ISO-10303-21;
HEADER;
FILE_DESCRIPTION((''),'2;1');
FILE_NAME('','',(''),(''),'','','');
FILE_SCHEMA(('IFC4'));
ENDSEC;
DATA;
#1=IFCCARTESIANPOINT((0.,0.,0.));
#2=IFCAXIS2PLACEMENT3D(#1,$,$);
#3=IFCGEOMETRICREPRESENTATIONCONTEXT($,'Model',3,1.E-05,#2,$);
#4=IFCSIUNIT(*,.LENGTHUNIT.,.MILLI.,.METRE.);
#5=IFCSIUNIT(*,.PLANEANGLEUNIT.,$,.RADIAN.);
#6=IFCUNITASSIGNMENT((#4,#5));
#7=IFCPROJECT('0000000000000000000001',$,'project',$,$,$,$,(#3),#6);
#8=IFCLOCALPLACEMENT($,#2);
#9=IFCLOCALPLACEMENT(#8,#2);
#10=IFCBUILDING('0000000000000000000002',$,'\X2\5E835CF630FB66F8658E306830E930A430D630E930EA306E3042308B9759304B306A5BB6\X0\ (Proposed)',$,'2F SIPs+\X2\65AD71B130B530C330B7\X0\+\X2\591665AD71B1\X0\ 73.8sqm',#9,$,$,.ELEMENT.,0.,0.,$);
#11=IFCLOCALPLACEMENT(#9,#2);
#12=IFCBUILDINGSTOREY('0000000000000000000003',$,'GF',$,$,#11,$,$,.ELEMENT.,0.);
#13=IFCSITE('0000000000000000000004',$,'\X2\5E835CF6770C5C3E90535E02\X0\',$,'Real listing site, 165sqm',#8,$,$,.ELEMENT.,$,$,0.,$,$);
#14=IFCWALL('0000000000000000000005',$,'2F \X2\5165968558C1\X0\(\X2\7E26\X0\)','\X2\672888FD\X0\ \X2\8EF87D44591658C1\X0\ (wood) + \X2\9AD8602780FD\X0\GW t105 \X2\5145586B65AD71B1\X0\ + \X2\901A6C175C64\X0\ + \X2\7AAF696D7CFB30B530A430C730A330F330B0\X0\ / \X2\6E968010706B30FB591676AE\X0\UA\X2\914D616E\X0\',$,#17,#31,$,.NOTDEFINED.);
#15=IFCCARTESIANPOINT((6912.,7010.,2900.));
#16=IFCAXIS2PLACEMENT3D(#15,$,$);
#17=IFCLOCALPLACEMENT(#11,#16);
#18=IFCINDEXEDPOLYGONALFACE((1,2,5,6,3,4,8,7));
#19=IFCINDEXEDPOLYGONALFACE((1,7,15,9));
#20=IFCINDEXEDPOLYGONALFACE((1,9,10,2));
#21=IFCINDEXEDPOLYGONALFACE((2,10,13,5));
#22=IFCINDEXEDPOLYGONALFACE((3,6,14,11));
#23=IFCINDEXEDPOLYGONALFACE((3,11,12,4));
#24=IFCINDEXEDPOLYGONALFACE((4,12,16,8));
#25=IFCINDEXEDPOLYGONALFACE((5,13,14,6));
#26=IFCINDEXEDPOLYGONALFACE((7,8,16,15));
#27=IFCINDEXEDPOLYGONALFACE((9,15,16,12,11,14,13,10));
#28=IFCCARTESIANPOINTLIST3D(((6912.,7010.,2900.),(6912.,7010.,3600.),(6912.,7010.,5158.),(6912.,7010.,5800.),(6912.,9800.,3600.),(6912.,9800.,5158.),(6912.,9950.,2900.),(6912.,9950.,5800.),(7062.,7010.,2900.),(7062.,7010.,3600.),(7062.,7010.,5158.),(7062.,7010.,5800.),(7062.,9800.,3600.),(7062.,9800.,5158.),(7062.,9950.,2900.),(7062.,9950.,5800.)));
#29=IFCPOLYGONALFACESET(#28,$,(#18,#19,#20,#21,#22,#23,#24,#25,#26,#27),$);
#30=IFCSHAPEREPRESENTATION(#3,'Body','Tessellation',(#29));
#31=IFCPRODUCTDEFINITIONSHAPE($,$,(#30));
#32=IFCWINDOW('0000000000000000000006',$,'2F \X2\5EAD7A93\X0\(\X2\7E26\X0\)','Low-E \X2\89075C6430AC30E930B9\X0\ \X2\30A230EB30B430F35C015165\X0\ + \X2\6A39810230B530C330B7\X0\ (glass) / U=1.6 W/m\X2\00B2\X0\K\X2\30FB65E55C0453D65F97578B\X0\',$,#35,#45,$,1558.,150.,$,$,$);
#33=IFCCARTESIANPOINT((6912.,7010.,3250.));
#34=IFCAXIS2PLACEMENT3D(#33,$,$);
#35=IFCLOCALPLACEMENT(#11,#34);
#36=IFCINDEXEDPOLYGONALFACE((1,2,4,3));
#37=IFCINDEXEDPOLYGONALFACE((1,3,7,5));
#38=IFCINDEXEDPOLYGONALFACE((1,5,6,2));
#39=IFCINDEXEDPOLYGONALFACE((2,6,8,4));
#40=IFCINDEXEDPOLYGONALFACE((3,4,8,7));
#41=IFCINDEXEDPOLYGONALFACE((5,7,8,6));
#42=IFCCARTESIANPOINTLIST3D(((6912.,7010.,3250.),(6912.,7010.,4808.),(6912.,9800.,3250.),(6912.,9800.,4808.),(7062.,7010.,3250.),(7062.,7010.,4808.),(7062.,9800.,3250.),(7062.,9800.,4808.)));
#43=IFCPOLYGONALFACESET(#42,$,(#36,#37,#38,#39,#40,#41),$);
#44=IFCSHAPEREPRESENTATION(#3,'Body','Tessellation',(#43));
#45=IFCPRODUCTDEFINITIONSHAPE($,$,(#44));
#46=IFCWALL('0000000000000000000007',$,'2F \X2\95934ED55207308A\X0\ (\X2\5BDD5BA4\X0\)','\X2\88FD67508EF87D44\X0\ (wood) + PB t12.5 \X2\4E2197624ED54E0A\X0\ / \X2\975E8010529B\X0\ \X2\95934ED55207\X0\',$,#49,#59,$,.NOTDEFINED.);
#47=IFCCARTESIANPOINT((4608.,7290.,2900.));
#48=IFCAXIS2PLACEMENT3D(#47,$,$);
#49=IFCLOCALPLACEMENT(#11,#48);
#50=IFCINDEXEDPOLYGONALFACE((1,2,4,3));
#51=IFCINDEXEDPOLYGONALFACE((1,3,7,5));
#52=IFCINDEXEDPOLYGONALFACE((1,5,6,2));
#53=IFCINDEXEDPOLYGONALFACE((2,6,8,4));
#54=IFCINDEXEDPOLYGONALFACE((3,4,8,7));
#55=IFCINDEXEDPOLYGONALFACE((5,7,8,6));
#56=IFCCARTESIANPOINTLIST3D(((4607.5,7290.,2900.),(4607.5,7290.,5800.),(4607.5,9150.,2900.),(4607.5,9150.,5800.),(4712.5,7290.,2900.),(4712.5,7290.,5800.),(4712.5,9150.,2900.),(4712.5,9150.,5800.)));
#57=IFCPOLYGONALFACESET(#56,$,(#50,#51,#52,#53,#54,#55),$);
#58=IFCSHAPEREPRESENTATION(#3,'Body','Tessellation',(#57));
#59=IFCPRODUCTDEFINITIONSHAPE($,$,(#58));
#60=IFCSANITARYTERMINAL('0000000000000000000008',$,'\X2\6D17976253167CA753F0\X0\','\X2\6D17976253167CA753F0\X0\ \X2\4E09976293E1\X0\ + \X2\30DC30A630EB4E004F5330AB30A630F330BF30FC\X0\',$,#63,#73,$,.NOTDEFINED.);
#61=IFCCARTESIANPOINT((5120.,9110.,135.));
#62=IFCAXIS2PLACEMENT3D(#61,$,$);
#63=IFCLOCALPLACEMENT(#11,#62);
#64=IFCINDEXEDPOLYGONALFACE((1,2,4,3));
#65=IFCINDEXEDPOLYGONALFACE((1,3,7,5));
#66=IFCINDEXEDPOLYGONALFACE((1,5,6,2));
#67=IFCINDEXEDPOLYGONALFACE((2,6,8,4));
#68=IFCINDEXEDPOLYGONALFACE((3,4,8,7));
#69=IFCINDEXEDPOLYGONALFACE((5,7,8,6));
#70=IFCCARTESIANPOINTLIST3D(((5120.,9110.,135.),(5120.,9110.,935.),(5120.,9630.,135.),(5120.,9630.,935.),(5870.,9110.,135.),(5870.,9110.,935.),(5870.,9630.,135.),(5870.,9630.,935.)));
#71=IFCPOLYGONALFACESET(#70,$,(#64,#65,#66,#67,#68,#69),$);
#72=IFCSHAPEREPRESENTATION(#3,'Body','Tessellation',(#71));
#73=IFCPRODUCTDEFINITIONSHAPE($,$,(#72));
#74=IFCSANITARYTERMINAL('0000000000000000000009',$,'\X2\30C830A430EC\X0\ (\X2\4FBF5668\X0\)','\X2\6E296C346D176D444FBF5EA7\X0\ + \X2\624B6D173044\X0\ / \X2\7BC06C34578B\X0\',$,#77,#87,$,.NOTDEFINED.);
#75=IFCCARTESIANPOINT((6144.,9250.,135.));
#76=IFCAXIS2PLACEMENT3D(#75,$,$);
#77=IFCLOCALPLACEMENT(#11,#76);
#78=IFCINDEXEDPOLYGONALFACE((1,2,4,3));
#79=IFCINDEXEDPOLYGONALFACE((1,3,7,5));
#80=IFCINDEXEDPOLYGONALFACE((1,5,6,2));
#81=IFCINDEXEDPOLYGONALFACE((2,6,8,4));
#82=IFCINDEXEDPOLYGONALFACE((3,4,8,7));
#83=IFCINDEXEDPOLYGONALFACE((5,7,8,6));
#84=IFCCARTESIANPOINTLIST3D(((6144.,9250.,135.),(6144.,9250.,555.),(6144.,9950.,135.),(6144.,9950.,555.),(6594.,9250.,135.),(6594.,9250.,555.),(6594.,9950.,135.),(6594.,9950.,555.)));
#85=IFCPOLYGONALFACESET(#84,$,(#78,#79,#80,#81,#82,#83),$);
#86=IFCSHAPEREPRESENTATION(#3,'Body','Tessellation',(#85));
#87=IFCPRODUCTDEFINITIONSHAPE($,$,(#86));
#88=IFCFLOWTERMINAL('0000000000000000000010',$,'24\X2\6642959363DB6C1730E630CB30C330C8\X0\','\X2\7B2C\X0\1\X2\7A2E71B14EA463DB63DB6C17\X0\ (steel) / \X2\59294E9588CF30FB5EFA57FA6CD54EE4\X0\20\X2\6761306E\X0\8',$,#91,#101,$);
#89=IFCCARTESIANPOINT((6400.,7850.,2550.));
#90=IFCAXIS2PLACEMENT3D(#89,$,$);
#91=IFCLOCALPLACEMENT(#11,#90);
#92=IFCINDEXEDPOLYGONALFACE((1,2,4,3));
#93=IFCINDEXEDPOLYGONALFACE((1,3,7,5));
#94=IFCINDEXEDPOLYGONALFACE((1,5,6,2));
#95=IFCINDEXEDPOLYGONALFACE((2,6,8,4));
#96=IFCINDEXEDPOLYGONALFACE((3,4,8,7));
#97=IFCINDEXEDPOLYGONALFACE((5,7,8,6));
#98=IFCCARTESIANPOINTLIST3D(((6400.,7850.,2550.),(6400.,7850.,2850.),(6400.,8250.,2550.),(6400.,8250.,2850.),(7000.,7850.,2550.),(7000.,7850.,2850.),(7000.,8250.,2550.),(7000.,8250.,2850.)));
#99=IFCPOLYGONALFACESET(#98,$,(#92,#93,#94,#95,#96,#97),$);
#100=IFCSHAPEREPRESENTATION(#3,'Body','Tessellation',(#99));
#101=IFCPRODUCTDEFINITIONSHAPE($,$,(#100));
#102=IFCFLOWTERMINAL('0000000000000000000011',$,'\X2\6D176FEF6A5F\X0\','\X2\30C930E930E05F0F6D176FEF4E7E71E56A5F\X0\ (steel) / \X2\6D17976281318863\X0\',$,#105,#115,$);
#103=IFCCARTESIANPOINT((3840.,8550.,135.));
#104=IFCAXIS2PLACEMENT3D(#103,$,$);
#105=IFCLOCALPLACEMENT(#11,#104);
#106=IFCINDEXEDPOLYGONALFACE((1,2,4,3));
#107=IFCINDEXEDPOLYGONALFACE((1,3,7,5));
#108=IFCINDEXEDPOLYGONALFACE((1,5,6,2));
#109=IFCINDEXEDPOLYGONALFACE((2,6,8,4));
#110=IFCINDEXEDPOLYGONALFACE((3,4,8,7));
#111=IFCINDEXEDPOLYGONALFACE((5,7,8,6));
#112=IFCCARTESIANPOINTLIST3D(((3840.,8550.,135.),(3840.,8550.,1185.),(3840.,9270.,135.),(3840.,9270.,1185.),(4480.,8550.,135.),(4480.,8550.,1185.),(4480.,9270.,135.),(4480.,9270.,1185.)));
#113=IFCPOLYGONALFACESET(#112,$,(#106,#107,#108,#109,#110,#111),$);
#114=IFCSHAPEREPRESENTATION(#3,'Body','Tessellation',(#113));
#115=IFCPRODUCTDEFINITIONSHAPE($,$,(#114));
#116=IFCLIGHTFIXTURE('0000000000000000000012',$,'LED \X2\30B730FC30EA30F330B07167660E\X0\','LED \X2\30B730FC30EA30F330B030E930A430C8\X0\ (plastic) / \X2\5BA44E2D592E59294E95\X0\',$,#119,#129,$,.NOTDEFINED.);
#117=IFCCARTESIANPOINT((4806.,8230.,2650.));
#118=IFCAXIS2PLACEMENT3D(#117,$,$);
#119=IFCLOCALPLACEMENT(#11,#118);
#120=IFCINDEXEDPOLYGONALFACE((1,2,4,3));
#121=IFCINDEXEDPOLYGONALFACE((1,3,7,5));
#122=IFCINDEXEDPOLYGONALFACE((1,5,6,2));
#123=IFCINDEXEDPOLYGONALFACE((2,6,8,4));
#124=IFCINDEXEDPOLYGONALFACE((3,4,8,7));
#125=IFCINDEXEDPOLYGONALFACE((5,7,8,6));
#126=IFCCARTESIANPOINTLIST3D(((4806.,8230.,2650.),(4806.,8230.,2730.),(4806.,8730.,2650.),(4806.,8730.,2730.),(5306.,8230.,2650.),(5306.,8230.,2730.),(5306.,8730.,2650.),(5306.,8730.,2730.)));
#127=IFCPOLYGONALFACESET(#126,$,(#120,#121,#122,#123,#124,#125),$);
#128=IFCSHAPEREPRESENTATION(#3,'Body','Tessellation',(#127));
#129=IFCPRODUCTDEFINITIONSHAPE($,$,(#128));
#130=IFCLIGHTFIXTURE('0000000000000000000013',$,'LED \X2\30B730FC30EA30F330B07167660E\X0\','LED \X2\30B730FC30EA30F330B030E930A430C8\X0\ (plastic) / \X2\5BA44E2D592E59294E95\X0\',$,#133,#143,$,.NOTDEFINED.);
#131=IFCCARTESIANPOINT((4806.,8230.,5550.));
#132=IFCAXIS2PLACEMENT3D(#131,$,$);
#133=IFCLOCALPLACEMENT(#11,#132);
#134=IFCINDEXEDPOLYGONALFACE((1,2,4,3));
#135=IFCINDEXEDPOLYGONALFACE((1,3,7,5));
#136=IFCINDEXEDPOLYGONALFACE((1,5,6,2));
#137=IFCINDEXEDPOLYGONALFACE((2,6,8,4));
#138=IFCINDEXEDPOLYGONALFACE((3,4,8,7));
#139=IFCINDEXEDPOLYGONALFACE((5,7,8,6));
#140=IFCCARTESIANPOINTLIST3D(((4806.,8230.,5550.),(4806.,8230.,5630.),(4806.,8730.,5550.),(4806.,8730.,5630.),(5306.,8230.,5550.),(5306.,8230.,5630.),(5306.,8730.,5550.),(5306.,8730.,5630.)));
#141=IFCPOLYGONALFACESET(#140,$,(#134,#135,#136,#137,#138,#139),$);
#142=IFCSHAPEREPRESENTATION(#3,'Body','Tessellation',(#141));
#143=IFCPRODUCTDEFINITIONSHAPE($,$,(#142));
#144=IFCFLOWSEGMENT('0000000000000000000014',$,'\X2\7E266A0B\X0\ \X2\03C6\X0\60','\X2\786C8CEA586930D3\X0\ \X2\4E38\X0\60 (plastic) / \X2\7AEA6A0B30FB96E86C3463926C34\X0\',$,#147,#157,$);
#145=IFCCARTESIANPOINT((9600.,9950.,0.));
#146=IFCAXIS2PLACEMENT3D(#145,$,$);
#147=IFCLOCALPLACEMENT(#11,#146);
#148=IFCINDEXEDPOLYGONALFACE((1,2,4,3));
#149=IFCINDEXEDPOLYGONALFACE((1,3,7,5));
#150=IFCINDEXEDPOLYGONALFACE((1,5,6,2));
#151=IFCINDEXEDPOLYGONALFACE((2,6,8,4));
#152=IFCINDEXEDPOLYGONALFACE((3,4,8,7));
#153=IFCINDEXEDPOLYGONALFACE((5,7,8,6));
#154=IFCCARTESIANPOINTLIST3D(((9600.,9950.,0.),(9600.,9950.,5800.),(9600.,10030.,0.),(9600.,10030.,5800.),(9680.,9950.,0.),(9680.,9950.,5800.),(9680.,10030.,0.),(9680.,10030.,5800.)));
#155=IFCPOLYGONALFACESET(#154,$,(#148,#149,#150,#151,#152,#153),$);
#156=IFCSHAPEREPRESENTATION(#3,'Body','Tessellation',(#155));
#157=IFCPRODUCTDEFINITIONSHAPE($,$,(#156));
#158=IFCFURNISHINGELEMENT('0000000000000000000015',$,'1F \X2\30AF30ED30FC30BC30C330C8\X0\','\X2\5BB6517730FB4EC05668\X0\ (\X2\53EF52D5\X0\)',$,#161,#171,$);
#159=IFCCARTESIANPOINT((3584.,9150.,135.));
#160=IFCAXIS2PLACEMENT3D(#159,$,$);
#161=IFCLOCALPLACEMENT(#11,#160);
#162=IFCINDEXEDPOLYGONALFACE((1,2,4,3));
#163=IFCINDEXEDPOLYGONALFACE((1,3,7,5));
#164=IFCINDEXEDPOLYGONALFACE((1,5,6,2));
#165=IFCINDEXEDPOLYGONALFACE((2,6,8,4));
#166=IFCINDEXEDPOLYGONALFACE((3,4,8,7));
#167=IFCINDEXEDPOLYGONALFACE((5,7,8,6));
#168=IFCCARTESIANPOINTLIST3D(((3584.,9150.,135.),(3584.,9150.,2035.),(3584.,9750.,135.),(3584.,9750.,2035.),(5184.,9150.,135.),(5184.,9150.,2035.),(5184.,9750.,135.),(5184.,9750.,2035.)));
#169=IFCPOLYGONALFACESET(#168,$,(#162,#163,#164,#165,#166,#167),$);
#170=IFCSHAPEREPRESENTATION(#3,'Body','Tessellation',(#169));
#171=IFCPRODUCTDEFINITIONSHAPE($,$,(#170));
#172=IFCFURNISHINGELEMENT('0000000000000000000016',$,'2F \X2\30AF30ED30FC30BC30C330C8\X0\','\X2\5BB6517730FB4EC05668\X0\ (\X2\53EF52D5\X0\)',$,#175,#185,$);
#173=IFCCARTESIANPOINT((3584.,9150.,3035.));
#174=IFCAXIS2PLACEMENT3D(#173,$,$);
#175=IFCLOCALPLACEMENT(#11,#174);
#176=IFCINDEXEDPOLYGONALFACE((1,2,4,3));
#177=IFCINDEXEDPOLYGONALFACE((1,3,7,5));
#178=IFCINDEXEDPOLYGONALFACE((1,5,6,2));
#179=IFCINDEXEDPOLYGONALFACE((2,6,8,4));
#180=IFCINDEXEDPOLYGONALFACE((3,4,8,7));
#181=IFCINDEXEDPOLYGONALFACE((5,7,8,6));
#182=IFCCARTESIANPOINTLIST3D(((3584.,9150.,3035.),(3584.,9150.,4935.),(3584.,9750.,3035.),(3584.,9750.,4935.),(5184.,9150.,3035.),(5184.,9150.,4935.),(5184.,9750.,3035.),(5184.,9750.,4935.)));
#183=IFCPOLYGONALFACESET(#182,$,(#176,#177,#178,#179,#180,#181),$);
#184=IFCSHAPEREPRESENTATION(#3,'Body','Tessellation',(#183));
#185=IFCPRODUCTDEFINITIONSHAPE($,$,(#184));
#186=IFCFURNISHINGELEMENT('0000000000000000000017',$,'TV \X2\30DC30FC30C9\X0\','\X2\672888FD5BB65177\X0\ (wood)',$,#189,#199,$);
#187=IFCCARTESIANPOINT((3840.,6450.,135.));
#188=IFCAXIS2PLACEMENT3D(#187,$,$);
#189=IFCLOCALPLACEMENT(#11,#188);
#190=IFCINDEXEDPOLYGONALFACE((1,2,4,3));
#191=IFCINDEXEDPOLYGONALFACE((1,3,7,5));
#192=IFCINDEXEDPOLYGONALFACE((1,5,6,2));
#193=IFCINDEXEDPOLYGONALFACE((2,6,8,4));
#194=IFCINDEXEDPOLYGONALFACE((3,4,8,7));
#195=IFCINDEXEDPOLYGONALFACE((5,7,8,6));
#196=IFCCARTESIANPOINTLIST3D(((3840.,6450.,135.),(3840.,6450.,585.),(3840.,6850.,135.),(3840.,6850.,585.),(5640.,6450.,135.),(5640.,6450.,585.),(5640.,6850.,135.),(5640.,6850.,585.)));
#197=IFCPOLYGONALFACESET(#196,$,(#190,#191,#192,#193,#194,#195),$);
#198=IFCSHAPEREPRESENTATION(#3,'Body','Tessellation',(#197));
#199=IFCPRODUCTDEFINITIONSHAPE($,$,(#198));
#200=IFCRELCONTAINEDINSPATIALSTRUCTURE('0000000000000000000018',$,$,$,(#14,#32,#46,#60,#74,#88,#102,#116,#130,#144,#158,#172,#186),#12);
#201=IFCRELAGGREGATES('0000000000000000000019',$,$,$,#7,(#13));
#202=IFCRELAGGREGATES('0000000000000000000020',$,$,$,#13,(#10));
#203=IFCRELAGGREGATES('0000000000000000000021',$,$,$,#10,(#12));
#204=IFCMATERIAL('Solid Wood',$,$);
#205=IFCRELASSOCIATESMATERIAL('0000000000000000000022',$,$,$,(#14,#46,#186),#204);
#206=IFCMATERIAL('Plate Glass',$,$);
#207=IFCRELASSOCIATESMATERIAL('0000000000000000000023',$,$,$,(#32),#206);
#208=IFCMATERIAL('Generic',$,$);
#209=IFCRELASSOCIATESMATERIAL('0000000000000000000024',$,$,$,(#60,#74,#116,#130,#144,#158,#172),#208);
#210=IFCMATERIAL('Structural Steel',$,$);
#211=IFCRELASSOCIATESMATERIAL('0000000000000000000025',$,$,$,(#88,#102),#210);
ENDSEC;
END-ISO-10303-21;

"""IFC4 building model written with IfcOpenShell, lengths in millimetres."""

from ifc_helpers import new_model, si_unit, frame, frame_2d, origin, place, context, project, spatial, rectangle, extrude, material, element, fill, save


model = new_model("IFC4")

# Units and contexts
model_context = context("Model", 3, precision=1e-05, world=origin())
ifc_project = project(units=[si_unit("LENGTHUNIT", "METRE", prefix="MILLI"), si_unit("PLANEANGLEUNIT", "RADIAN")], contexts=[model_context])

# Site, building, storey
site_placement = place(None, origin())
site = spatial("IfcSite", under=ifc_project, at=site_placement, Name="広島県尾道市", ObjectType="Real listing site, 165sqm", CompositionType="ELEMENT", RefElevation=0.0)
building_placement = place(site_placement, origin())
building = spatial("IfcBuilding", under=site, at=building_placement, Name="広島・書斎とライブラリのある静かな家 (Proposed)", ObjectType="2F SIPs+断熱サッシ+外断熱 73.8sqm", CompositionType="ELEMENT", ElevationOfRefHeight=0.0, ElevationOfTerrain=0.0)
storey_placement = place(building_placement, origin())
storey = spatial("IfcBuildingStorey", under=building, at=storey_placement, Name="GF", CompositionType="ELEMENT", Elevation=0.0)

# Shared definitions
ifc_material_1 = material(Name="Solid Wood")

# Shared definitions
ifc_material_2 = material(Name="Plate Glass")

# Wall, opening, window
wall_1_placement = place(storey_placement, frame((6912.0, 7010.0, 2900.0)))
wall_1 = element("IfcWall", 1, at=wall_1_placement, inside=storey, material=ifc_material_1, Name="2F 入隅壁(縦)", Description="木製 軸組外壁 (wood) + 高性能GW t105 充填断熱 + 通気層 + 窯業系サイディング / 準耐火・外皮UA配慮", PredefinedType="NOTDEFINED", context=model_context, shape_type="SweptSolid", body=[
    extrude(rectangle(XDim=150.0, YDim=2940.0, at=frame_2d((75.0, 1470.0))), frame((6912.0, 7010.0, 2900.0)), (0.0, 0.0, 1.0), 2900.0),
])
opening_1_placement = place(storey_placement, frame((6912.0, 7010.0, 3250.0)))
opening_1 = element("IfcOpeningElement", 2, at=opening_1_placement, cuts=wall_1, PredefinedType="NOTDEFINED", context=model_context, shape_type="SweptSolid", body=[
    extrude(rectangle(XDim=150.0, YDim=2790.0, at=frame_2d((75.0, 1395.0))), frame((6912.0, 7010.0, 3250.0)), (0.0, 0.0, 1.0), 1558.0),
])
window_1_placement = place(storey_placement, frame((6912.0, 7010.0, 3250.0)))
window_1 = element("IfcWindow", 3, at=window_1_placement, inside=storey, material=ifc_material_2, Name="2F 庭窓(縦)", Description="Low-E 複層ガラス アルゴン封入 + 樹脂サッシ (glass) / U=1.6 W/m²K・日射取得型", OverallHeight=1558.0, OverallWidth=150.0, context=model_context, shape_type="SweptSolid", body=[
    extrude(rectangle(XDim=150.0, YDim=2790.0, at=frame_2d((75.0, 1395.0))), frame((6912.0, 7010.0, 3250.0)), (0.0, 0.0, 1.0), 1558.0),
])
fill(opening_1, window_1)

# Wall
wall_2_placement = place(storey_placement, frame((4608.0, 7290.0, 2900.0)))
element("IfcWall", 4, at=wall_2_placement, inside=storey, material=ifc_material_1, Name="2F 間仕切り (寝室)", Description="製材軸組 (wood) + PB t12.5 両面仕上 / 非耐力 間仕切", PredefinedType="NOTDEFINED", context=model_context, shape_type="SweptSolid", body=[
    extrude(rectangle(XDim=105.0, YDim=1860.0, at=frame_2d((52.0, 930.0))), frame((4608.0, 7290.0, 2900.0)), (0.0, 0.0, 1.0), 2900.0),
])

# Sanitary terminals
ifc_material_3 = material(Name="Generic")
sanitary_terminal_1_placement = place(storey_placement, frame((5120.0, 9110.0, 135.0)))
element("IfcSanitaryTerminal", 5, at=sanitary_terminal_1_placement, inside=storey, material=ifc_material_3, Name="洗面化粧台", Description="洗面化粧台 三面鏡 + ボウル一体カウンター", PredefinedType="NOTDEFINED", context=model_context, shape_type="SweptSolid", body=[
    extrude(rectangle(XDim=750.0, YDim=520.0, at=frame_2d((375.0, 260.0))), frame((5120.0, 9110.0, 135.0)), (0.0, 0.0, 1.0), 800.0),
])
sanitary_terminal_2_placement = place(storey_placement, frame((6144.0, 9250.0, 135.0)))
element("IfcSanitaryTerminal", 6, at=sanitary_terminal_2_placement, inside=storey, material=ifc_material_3, Name="トイレ (便器)", Description="温水洗浄便座 + 手洗い / 節水型", PredefinedType="NOTDEFINED", context=model_context, shape_type="SweptSolid", body=[
    extrude(rectangle(XDim=450.0, YDim=700.0, at=frame_2d((225.0, 350.0))), frame((6144.0, 9250.0, 135.0)), (0.0, 0.0, 1.0), 420.0),
])

# Flow terminals
ifc_material_4 = material(Name="Structural Steel")
flow_terminal_1_placement = place(storey_placement, frame((6400.0, 7850.0, 2550.0)))
element("IfcFlowTerminal", 7, at=flow_terminal_1_placement, inside=storey, material=ifc_material_4, Name="24時間換気ユニット", Description="第1種熱交換換気 (steel) / 天井裏・建基法令20条の8", context=model_context, shape_type="SweptSolid", body=[
    extrude(rectangle(XDim=600.0, YDim=400.0, at=frame_2d((300.0, 200.0))), frame((6400.0, 7850.0, 2550.0)), (0.0, 0.0, 1.0), 300.0),
])
flow_terminal_2_placement = place(storey_placement, frame((3840.0, 8550.0, 135.0)))
element("IfcFlowTerminal", 8, at=flow_terminal_2_placement, inside=storey, material=ifc_material_4, Name="洗濯機", Description="ドラム式洗濯乾燥機 (steel) / 洗面脱衣", context=model_context, shape_type="SweptSolid", body=[
    extrude(rectangle(XDim=640.0, YDim=720.0, at=frame_2d((320.0, 360.0))), frame((3840.0, 8550.0, 135.0)), (0.0, 0.0, 1.0), 1050.0),
])

# Light fixtures
light_fixture_1_placement = place(storey_placement, frame((4806.0, 8230.0, 2650.0)))
element("IfcLightFixture", 9, at=light_fixture_1_placement, inside=storey, material=ifc_material_3, Name="LED シーリング照明", Description="LED シーリングライト (plastic) / 室中央天井", PredefinedType="NOTDEFINED", context=model_context, shape_type="SweptSolid", body=[
    extrude(rectangle(XDim=500.0, YDim=500.0, at=frame_2d((250.0, 250.0))), frame((4806.0, 8230.0, 2650.0)), (0.0, 0.0, 1.0), 80.0),
])
light_fixture_2_placement = place(storey_placement, frame((4806.0, 8230.0, 5550.0)))
element("IfcLightFixture", 10, at=light_fixture_2_placement, inside=storey, material=ifc_material_3, Name="LED シーリング照明", Description="LED シーリングライト (plastic) / 室中央天井", PredefinedType="NOTDEFINED", context=model_context, shape_type="SweptSolid", body=[
    extrude(rectangle(XDim=500.0, YDim=500.0, at=frame_2d((250.0, 250.0))), frame((4806.0, 8230.0, 5550.0)), (0.0, 0.0, 1.0), 80.0),
])

# Flow segment
flow_segment_placement = place(storey_placement, frame((9600.0, 9950.0, 0.0)))
element("IfcFlowSegment", 11, at=flow_segment_placement, inside=storey, material=ifc_material_3, Name="縦樋 φ60", Description="硬質塩ビ 丸60 (plastic) / 竪樋・雨水排水", context=model_context, shape_type="SweptSolid", body=[
    extrude(rectangle(XDim=80.0, YDim=80.0, at=frame_2d((40.0, 40.0))), frame((9600.0, 9950.0, 0.0)), (0.0, 0.0, 1.0), 5800.0),
])

# Furnishing elements
furnishing_1_placement = place(storey_placement, frame((3584.0, 9150.0, 135.0)))
element("IfcFurnishingElement", 12, at=furnishing_1_placement, inside=storey, material=ifc_material_3, Name="1F クローゼット", Description="家具・什器 (可動)", context=model_context, shape_type="SweptSolid", body=[
    extrude(rectangle(XDim=1600.0, YDim=600.0, at=frame_2d((800.0, 300.0))), frame((3584.0, 9150.0, 135.0)), (0.0, 0.0, 1.0), 1900.0),
])
furnishing_2_placement = place(storey_placement, frame((3584.0, 9150.0, 3035.0)))
element("IfcFurnishingElement", 13, at=furnishing_2_placement, inside=storey, material=ifc_material_3, Name="2F クローゼット", Description="家具・什器 (可動)", context=model_context, shape_type="SweptSolid", body=[
    extrude(rectangle(XDim=1600.0, YDim=600.0, at=frame_2d((800.0, 300.0))), frame((3584.0, 9150.0, 3035.0)), (0.0, 0.0, 1.0), 1900.0),
])
furnishing_3_placement = place(storey_placement, frame((3840.0, 6450.0, 135.0)))
element("IfcFurnishingElement", 14, at=furnishing_3_placement, inside=storey, material=ifc_material_1, Name="TV ボード", Description="木製家具 (wood)", context=model_context, shape_type="SweptSolid", body=[
    extrude(rectangle(XDim=1800.0, YDim=400.0, at=frame_2d((900.0, 200.0))), frame((3840.0, 6450.0, 135.0)), (0.0, 0.0, 1.0), 450.0),
])

save(model, "model.ifc")
